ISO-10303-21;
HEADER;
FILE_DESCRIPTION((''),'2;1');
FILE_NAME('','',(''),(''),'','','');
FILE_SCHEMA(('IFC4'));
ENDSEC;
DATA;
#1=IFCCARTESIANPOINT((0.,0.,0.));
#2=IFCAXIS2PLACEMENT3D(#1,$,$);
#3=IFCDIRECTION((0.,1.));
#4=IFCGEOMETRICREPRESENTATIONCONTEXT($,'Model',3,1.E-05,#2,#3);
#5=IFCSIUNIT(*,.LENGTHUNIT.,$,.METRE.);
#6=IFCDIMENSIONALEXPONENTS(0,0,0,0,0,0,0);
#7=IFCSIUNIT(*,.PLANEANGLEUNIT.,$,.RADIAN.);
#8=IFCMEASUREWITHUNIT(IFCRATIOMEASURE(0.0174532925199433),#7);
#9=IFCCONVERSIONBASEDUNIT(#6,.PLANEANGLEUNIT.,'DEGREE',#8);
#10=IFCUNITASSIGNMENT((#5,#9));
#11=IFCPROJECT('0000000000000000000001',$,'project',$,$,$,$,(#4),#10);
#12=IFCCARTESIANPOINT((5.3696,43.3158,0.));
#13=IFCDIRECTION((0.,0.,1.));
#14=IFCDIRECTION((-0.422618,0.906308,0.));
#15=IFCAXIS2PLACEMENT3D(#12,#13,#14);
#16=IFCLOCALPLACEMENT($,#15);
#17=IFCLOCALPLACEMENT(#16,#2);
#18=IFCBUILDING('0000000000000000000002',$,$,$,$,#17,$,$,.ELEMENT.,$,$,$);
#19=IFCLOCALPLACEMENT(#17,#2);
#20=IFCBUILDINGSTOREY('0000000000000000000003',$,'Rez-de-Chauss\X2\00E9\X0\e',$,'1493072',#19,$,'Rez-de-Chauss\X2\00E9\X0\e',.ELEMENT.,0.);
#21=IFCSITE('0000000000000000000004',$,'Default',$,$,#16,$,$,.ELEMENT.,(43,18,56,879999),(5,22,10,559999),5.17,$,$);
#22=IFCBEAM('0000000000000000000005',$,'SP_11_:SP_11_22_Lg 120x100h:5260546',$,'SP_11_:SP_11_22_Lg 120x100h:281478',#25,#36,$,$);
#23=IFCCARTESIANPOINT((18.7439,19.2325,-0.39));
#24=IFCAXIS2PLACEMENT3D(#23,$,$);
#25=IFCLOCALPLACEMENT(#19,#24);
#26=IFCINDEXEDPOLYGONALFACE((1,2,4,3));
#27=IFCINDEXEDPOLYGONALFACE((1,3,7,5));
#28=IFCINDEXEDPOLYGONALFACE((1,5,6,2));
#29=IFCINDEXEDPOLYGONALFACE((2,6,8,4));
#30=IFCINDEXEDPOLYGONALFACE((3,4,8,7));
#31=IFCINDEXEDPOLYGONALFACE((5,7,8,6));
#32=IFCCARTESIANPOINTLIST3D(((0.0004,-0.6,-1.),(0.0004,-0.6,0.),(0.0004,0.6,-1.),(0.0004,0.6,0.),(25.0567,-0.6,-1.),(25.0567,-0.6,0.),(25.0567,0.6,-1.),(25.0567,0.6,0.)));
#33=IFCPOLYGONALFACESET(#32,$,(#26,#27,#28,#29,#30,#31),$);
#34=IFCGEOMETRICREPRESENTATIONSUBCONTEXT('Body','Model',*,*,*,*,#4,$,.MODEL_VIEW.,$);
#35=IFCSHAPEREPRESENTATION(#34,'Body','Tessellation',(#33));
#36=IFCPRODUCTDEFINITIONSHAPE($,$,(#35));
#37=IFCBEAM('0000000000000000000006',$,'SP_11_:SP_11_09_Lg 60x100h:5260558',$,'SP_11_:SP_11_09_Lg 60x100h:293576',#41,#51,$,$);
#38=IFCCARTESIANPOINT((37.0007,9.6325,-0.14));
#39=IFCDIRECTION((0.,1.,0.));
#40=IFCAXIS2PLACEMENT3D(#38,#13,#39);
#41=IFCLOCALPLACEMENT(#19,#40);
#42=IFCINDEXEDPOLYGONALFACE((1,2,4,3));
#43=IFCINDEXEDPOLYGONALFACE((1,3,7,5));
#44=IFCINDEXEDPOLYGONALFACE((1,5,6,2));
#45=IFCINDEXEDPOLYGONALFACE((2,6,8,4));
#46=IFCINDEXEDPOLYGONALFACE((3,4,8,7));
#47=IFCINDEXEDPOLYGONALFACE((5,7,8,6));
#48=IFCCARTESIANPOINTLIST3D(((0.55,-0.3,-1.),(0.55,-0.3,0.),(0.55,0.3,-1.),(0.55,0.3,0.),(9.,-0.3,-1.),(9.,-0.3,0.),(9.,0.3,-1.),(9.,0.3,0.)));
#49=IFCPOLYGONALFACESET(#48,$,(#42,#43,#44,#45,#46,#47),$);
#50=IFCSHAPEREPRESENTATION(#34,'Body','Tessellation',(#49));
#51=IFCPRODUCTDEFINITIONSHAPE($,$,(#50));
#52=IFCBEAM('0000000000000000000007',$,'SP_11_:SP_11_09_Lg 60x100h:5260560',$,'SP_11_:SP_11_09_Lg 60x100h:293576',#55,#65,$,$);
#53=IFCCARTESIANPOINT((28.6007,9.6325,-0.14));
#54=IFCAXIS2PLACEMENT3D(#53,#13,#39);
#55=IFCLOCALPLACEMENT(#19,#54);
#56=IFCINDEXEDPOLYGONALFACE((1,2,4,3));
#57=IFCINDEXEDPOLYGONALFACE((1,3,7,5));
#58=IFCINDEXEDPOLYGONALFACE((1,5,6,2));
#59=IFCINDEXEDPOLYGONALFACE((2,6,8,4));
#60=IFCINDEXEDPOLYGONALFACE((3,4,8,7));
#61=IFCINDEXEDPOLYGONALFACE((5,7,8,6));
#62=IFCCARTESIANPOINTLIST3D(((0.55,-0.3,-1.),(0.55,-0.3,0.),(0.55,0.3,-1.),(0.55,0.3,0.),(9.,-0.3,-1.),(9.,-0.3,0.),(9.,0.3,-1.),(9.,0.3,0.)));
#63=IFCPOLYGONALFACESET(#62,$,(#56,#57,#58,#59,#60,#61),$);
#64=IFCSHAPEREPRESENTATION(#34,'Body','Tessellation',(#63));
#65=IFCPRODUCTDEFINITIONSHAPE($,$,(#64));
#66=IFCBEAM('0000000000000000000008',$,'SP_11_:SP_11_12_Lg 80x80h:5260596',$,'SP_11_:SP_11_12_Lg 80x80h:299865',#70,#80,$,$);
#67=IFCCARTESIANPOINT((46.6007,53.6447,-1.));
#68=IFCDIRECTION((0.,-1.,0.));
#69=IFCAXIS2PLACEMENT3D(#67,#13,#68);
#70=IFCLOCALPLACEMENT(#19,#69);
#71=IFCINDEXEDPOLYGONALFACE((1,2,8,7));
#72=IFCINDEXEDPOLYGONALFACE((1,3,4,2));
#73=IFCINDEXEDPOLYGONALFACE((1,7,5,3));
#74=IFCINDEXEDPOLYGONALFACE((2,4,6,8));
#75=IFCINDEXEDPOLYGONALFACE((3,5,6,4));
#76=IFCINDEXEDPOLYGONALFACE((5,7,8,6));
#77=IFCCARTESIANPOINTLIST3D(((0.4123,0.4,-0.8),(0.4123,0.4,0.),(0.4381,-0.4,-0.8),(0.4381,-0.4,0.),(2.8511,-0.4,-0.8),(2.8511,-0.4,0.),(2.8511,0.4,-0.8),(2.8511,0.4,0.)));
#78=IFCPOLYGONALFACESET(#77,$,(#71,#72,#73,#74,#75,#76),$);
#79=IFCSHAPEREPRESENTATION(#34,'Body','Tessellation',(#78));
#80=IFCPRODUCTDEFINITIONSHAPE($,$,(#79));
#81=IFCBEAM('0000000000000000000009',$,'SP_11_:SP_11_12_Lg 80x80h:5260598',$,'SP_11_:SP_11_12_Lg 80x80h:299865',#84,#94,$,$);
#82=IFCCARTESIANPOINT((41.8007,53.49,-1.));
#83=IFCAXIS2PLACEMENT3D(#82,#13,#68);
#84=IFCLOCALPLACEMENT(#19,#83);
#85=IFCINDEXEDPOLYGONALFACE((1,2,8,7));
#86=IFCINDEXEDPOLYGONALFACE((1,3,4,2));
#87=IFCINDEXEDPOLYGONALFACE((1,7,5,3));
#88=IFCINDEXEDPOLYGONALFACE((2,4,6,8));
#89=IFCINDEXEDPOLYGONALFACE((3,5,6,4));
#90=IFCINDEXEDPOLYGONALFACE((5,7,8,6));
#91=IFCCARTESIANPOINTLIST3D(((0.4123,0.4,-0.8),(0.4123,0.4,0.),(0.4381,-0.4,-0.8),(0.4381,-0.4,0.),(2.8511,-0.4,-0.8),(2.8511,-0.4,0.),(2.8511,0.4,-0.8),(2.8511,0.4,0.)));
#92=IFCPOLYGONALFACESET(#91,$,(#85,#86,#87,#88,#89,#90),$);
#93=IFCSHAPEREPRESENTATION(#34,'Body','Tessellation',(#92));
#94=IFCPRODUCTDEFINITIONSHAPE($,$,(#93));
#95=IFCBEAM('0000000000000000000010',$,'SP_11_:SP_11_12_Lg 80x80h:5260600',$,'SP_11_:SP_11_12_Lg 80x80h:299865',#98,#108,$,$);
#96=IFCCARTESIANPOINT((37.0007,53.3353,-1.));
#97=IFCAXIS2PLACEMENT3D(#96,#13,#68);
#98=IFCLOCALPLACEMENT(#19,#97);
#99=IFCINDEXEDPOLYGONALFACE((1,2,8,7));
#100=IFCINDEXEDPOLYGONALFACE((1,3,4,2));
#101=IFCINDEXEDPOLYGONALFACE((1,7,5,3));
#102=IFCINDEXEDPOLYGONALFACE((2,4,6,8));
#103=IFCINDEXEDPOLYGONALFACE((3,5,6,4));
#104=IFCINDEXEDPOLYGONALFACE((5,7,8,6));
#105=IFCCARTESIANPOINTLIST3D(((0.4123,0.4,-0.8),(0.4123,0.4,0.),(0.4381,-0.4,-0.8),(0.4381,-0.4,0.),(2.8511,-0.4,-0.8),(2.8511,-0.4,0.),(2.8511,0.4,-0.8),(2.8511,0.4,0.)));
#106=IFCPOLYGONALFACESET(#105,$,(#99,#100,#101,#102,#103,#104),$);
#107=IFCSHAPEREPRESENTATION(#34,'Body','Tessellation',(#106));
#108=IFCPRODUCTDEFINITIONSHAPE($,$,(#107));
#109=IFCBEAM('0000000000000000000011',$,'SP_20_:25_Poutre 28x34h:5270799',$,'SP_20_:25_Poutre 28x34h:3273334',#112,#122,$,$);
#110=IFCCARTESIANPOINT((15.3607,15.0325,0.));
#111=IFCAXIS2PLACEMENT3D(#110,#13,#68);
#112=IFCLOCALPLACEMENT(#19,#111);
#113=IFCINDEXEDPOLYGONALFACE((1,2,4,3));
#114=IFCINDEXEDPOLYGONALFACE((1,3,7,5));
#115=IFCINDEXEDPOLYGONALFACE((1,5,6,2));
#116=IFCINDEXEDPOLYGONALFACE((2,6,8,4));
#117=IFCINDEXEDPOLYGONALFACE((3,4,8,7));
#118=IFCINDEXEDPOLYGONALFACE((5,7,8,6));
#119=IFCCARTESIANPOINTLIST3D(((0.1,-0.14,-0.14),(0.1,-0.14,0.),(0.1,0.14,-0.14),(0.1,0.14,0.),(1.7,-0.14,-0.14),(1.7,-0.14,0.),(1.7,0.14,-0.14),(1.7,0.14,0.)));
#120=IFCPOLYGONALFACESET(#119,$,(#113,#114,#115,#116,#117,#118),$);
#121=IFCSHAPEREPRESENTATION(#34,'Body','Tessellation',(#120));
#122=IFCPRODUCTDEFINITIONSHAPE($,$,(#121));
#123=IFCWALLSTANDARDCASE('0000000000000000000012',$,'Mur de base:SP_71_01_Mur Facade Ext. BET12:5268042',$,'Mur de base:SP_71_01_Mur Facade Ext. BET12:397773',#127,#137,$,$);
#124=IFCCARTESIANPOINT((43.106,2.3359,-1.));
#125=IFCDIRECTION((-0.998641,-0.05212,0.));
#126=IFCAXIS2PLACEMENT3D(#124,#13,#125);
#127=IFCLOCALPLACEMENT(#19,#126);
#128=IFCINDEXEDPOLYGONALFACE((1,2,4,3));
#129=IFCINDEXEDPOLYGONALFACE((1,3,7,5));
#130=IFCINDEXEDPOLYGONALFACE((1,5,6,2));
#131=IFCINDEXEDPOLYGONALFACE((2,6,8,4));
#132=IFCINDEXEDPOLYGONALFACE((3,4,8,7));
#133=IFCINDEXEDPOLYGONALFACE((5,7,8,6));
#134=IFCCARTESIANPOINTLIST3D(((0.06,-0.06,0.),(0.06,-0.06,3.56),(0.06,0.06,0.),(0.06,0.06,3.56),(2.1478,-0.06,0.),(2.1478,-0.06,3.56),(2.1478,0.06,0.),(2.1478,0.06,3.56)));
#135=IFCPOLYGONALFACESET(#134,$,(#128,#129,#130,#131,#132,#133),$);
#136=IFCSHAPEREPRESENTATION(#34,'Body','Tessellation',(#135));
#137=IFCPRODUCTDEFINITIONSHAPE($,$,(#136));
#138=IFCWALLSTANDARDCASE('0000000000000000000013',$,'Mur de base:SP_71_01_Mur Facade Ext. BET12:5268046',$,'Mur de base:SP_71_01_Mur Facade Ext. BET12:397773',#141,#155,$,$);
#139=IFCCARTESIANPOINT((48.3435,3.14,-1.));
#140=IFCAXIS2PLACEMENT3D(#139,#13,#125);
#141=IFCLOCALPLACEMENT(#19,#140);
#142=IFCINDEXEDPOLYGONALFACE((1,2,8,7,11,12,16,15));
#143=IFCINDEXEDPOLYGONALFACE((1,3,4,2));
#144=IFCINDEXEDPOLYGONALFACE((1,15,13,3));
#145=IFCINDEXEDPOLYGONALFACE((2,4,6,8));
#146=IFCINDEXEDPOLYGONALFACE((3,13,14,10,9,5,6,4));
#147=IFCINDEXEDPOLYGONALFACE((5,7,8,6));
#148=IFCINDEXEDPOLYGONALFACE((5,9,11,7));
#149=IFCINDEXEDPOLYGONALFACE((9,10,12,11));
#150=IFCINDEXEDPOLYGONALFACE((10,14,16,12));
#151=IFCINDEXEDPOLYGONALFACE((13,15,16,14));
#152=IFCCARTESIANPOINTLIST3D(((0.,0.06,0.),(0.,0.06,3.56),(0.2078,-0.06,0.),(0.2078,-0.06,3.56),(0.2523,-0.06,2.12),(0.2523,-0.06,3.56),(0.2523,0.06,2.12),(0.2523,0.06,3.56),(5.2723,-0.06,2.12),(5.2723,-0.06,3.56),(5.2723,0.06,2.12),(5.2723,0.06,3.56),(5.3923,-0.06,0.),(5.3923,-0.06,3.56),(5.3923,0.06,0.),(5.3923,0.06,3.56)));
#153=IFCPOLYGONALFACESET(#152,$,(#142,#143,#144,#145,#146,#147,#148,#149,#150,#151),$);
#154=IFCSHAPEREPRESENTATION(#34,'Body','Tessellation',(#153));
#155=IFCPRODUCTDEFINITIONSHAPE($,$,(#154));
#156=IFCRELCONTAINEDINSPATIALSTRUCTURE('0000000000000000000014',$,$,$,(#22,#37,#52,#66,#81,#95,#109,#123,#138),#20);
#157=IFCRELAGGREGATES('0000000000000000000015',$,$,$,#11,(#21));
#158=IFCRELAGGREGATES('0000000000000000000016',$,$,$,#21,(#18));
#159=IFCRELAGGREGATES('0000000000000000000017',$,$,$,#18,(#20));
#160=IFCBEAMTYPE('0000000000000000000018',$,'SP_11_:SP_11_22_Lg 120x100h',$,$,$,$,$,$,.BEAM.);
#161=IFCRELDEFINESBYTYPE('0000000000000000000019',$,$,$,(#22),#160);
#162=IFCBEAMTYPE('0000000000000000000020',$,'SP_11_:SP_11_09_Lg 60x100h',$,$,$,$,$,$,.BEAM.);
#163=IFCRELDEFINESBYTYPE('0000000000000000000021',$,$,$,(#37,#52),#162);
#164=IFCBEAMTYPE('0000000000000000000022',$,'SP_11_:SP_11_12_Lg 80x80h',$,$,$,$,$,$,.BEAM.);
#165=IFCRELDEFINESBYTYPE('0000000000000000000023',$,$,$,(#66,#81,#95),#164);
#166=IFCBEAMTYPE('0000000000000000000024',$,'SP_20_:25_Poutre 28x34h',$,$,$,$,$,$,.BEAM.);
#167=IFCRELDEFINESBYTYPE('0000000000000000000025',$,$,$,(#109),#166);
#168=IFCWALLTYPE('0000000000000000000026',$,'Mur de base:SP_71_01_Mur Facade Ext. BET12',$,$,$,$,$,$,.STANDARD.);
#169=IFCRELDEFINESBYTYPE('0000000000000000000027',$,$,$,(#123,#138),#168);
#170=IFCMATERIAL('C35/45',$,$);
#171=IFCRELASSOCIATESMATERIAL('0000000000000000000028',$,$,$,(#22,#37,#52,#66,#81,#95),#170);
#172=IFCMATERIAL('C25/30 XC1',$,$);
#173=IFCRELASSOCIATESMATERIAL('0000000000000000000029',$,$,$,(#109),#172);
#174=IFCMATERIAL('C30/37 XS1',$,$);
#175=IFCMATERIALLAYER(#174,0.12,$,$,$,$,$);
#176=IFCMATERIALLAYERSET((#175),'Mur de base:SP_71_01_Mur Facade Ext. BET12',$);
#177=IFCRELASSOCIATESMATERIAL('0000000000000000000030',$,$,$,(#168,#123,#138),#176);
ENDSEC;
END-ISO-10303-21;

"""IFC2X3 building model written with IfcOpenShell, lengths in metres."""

from ifc_helpers import new_model, entity, si_unit, converted_unit, direction, frame, frame_2d, origin, place, context, subcontext, project, spatial, polyline, rectangle, outline, extrude, clip, halfspace, material, layer, layer_set, layer_usage, type_object, element, save


model = new_model("IFC2X3")

# Units and contexts
model_context = context("Model", 3, precision=1e-05, world=origin(), true_north=direction((0.0, 1.0)))
body_context = subcontext(model_context, "Body", "Model", "MODEL_VIEW")
ifc_project = project(units=[si_unit("LENGTHUNIT", "METRE"), converted_unit("PLANEANGLEUNIT", "DEGREE", entity("IfcRatioMeasure", 0.0174532925199433), si_unit("PLANEANGLEUNIT", "RADIAN"), dimensions=[0, 0, 0, 0, 0, 0, 0])], contexts=[model_context])

# Site, building, storey
site_placement = place(None, frame((5.3696, 43.3158, 0.0), z_axis=(0.0, 0.0, 1.0), x_axis=(-0.422618, 0.906308, 0.0)))
site = spatial("IfcSite", under=ifc_project, at=site_placement, Name="Default", CompositionType="ELEMENT", RefLatitude=(43, 18, 56, 879999), RefLongitude=(5, 22, 10, 559999), RefElevation=5.17)
building_placement = place(site_placement, origin())
building = spatial("IfcBuilding", under=site, at=building_placement, CompositionType="ELEMENT")
storey_placement = place(building_placement, origin())
storey = spatial("IfcBuildingStorey", under=building, at=storey_placement, Name="Rez-de-Chaussée", ObjectType="1493072", LongName="Rez-de-Chaussée", CompositionType="ELEMENT", Elevation=0.0)

# Beams
ifc_material_1 = material(Name="C35/45")
beam_type_1 = type_object("IfcBeamType", Name="SP_11_:SP_11_22_Lg 120x100h", PredefinedType="BEAM")
beam_1_placement = place(storey_placement, frame((18.7439, 19.2325, -0.39)))
element("IfcBeam", 1, at=beam_1_placement, inside=storey, type_object=beam_type_1, material=ifc_material_1, Name="SP_11_:SP_11_22_Lg 120x100h:5260546", ObjectType="SP_11_:SP_11_22_Lg 120x100h:281478", context=body_context, shape_type="SweptSolid", body=[
    extrude(rectangle(XDim=1.0, YDim=1.2, at=frame_2d((0.0, 0.0), x_axis=(1.0, 0.0))), frame((0.0004, 0.0, -0.5), z_axis=(1.0, 0.0, 0.0), x_axis=(0.0, 0.0, -1.0)), (0.0, 0.0, 1.0), 25.0564),
])
beam_type_2 = type_object("IfcBeamType", Name="SP_11_:SP_11_09_Lg 60x100h", PredefinedType="BEAM")
beam_2_placement = place(storey_placement, frame((37.0007, 9.6325, -0.14), z_axis=(0.0, 0.0, 1.0), x_axis=(0.0, 1.0, 0.0)))
element("IfcBeam", 2, at=beam_2_placement, inside=storey, type_object=beam_type_2, material=ifc_material_1, Name="SP_11_:SP_11_09_Lg 60x100h:5260558", ObjectType="SP_11_:SP_11_09_Lg 60x100h:293576", context=body_context, shape_type="SweptSolid", body=[
    extrude(rectangle(XDim=1.0, YDim=0.6, at=frame_2d((0.0, 0.0), x_axis=(1.0, 0.0))), frame((0.55, 0.0, -0.5), z_axis=(1.0, 0.0, 0.0), x_axis=(0.0, 0.0, -1.0)), (0.0, 0.0, 1.0), 8.45),
])
beam_3_placement = place(storey_placement, frame((28.6007, 9.6325, -0.14), z_axis=(0.0, 0.0, 1.0), x_axis=(0.0, 1.0, 0.0)))
element("IfcBeam", 3, at=beam_3_placement, inside=storey, type_object=beam_type_2, material=ifc_material_1, Name="SP_11_:SP_11_09_Lg 60x100h:5260560", ObjectType="SP_11_:SP_11_09_Lg 60x100h:293576", context=body_context, shape_type="SweptSolid", body=[
    extrude(rectangle(XDim=1.0, YDim=0.6, at=frame_2d((0.0, 0.0), x_axis=(1.0, 0.0))), frame((0.55, 0.0, -0.5), z_axis=(1.0, 0.0, 0.0), x_axis=(0.0, 0.0, -1.0)), (0.0, 0.0, 1.0), 8.45),
])
beam_type_3 = type_object("IfcBeamType", Name="SP_11_:SP_11_12_Lg 80x80h", PredefinedType="BEAM")
beam_4_placement = place(storey_placement, frame((46.6007, 53.6447, -1.0), z_axis=(0.0, 0.0, 1.0), x_axis=(0.0, -1.0, 0.0)))
element("IfcBeam", 4, at=beam_4_placement, inside=storey, type_object=beam_type_3, material=ifc_material_1, Name="SP_11_:SP_11_12_Lg 80x80h:5260596", ObjectType="SP_11_:SP_11_12_Lg 80x80h:299865", context=body_context, shape_type="Clipping", body=[
    clip(extrude(rectangle(XDim=0.8, YDim=0.8, at=frame_2d((0.0, 0.0), x_axis=(1.0, 0.0))), frame((0.4123, 0.0, -0.4), z_axis=(1.0, 0.0, 0.0), x_axis=(0.0, 0.0, -1.0)), (0.0, 0.0, 1.0), 2.4387), halfspace(frame((0.2815, 4.4599, 0.0), z_axis=(-0.999481, -0.032213, 0.0), x_axis=(0.032213, -0.999481, 0.0)), False)),
])
beam_5_placement = place(storey_placement, frame((41.8007, 53.49, -1.0), z_axis=(0.0, 0.0, 1.0), x_axis=(0.0, -1.0, 0.0)))
element("IfcBeam", 5, at=beam_5_placement, inside=storey, type_object=beam_type_3, material=ifc_material_1, Name="SP_11_:SP_11_12_Lg 80x80h:5260598", ObjectType="SP_11_:SP_11_12_Lg 80x80h:299865", context=body_context, shape_type="Clipping", body=[
    clip(extrude(rectangle(XDim=0.8, YDim=0.8, at=frame_2d((0.0, 0.0), x_axis=(1.0, 0.0))), frame((0.4123, 0.0, -0.4), z_axis=(1.0, 0.0, 0.0), x_axis=(0.0, 0.0, -1.0)), (0.0, 0.0, 1.0), 2.4387), halfspace(frame((0.1268, 9.2599, 0.0), z_axis=(-0.999481, -0.032213, 0.0), x_axis=(0.032213, -0.999481, 0.0)), False)),
])
beam_6_placement = place(storey_placement, frame((37.0007, 53.3353, -1.0), z_axis=(0.0, 0.0, 1.0), x_axis=(0.0, -1.0, 0.0)))
element("IfcBeam", 6, at=beam_6_placement, inside=storey, type_object=beam_type_3, material=ifc_material_1, Name="SP_11_:SP_11_12_Lg 80x80h:5260600", ObjectType="SP_11_:SP_11_12_Lg 80x80h:299865", context=body_context, shape_type="Clipping", body=[
    clip(extrude(rectangle(XDim=0.8, YDim=0.8, at=frame_2d((0.0, 0.0), x_axis=(1.0, 0.0))), frame((0.4123, 0.0, -0.4), z_axis=(1.0, 0.0, 0.0), x_axis=(0.0, 0.0, -1.0)), (0.0, 0.0, 1.0), 2.4387), halfspace(frame((-0.0279, 14.0599, 0.0), z_axis=(-0.999481, -0.032213, 0.0), x_axis=(0.032213, -0.999481, 0.0)), False)),
])
ifc_material_2 = material(Name="C25/30 XC1")
beam_type_4 = type_object("IfcBeamType", Name="SP_20_:25_Poutre 28x34h", PredefinedType="BEAM")
beam_7_placement = place(storey_placement, frame((15.3607, 15.0325, 0.0), z_axis=(0.0, 0.0, 1.0), x_axis=(0.0, -1.0, 0.0)))
element("IfcBeam", 7, at=beam_7_placement, inside=storey, type_object=beam_type_4, material=ifc_material_2, Name="SP_20_:25_Poutre 28x34h:5270799", ObjectType="SP_20_:25_Poutre 28x34h:3273334", context=body_context, shape_type="SweptSolid", body=[
    extrude(rectangle(XDim=0.14, YDim=0.28, at=frame_2d((0.0, 0.0), x_axis=(1.0, 0.0))), frame((0.1, 0.0, -0.07), z_axis=(1.0, 0.0, 0.0), x_axis=(0.0, 0.0, -1.0)), (0.0, 0.0, 1.0), 1.6),
])

# Shared definitions
ifc_material_3 = material(Name="C30/37 XS1")

# Wall
ifc_layer_1 = layer(ifc_material_3, 0.12)
ifc_layer_set_1 = layer_set([ifc_layer_1], Name="Mur de base:SP_71_01_Mur Facade Ext. BET12")
ifc_layer_usage_1 = layer_usage(ifc_layer_set_1, "AXIS2", "NEGATIVE", 0.06)
wall_type_1 = type_object("IfcWallType", Name="Mur de base:SP_71_01_Mur Facade Ext. BET12", PredefinedType="STANDARD", material=ifc_layer_set_1)
wall_1_placement = place(storey_placement, frame((43.106, 2.3359, -1.0), z_axis=(0.0, 0.0, 1.0), x_axis=(-0.998641, -0.05212, 0.0)))
element("IfcWallStandardCase", 8, at=wall_1_placement, inside=storey, type_object=wall_type_1, material=ifc_layer_usage_1, Name="Mur de base:SP_71_01_Mur Facade Ext. BET12:5268042", ObjectType="Mur de base:SP_71_01_Mur Facade Ext. BET12:397773", context=body_context, shape_type="Clipping", body=[
    clip(extrude(rectangle(XDim=2.0878, YDim=0.12, at=frame_2d((1.1039, 0.0), x_axis=(-1.0, 0.0))), origin(), (0.0, 0.0, 1.0), 3.56), halfspace(frame((0.0, 0.0, -1.0)), True)),
])

# Wall, opening
ifc_layer_usage_2 = layer_usage(ifc_layer_set_1, "AXIS2", "NEGATIVE", 0.06)
wall_2_placement = place(storey_placement, frame((48.3435, 3.14, -1.0), z_axis=(0.0, 0.0, 1.0), x_axis=(-0.998641, -0.05212, 0.0)))
wall_2 = element("IfcWallStandardCase", 9, at=wall_2_placement, inside=storey, type_object=wall_type_1, material=ifc_layer_usage_2, Name="Mur de base:SP_71_01_Mur Facade Ext. BET12:5268046", ObjectType="Mur de base:SP_71_01_Mur Facade Ext. BET12:397773", context=body_context, shape_type="Clipping", body=[
    clip(extrude(outline(polyline([(5.3923, -0.06), (5.3923, 0.06), (5.2723, 0.06), (0.24, 0.06), (0.0, 0.06), (0.2078, -0.06), (5.3923, -0.06)])), origin(), (0.0, 0.0, 1.0), 3.56), halfspace(frame((0.0, 0.0, -1.0)), True)),
])
opening_1_placement = place(wall_2_placement, origin())
element("IfcOpeningElement", 10, at=opening_1_placement, cuts=wall_2, ObjectType="Opening", context=body_context, shape_type="SweptSolid", body=[
    extrude(rectangle(XDim=2.24, YDim=5.02, at=frame_2d((0.0, 0.0), x_axis=(0.0, 1.0))), frame((2.7623, -1.584, 3.24), z_axis=(0.0, 1.0, 0.0), x_axis=(1.0, 0.0, 0.0)), (0.0, 0.0, 1.0), 3.048),
])

save(model, "model.ifc")
